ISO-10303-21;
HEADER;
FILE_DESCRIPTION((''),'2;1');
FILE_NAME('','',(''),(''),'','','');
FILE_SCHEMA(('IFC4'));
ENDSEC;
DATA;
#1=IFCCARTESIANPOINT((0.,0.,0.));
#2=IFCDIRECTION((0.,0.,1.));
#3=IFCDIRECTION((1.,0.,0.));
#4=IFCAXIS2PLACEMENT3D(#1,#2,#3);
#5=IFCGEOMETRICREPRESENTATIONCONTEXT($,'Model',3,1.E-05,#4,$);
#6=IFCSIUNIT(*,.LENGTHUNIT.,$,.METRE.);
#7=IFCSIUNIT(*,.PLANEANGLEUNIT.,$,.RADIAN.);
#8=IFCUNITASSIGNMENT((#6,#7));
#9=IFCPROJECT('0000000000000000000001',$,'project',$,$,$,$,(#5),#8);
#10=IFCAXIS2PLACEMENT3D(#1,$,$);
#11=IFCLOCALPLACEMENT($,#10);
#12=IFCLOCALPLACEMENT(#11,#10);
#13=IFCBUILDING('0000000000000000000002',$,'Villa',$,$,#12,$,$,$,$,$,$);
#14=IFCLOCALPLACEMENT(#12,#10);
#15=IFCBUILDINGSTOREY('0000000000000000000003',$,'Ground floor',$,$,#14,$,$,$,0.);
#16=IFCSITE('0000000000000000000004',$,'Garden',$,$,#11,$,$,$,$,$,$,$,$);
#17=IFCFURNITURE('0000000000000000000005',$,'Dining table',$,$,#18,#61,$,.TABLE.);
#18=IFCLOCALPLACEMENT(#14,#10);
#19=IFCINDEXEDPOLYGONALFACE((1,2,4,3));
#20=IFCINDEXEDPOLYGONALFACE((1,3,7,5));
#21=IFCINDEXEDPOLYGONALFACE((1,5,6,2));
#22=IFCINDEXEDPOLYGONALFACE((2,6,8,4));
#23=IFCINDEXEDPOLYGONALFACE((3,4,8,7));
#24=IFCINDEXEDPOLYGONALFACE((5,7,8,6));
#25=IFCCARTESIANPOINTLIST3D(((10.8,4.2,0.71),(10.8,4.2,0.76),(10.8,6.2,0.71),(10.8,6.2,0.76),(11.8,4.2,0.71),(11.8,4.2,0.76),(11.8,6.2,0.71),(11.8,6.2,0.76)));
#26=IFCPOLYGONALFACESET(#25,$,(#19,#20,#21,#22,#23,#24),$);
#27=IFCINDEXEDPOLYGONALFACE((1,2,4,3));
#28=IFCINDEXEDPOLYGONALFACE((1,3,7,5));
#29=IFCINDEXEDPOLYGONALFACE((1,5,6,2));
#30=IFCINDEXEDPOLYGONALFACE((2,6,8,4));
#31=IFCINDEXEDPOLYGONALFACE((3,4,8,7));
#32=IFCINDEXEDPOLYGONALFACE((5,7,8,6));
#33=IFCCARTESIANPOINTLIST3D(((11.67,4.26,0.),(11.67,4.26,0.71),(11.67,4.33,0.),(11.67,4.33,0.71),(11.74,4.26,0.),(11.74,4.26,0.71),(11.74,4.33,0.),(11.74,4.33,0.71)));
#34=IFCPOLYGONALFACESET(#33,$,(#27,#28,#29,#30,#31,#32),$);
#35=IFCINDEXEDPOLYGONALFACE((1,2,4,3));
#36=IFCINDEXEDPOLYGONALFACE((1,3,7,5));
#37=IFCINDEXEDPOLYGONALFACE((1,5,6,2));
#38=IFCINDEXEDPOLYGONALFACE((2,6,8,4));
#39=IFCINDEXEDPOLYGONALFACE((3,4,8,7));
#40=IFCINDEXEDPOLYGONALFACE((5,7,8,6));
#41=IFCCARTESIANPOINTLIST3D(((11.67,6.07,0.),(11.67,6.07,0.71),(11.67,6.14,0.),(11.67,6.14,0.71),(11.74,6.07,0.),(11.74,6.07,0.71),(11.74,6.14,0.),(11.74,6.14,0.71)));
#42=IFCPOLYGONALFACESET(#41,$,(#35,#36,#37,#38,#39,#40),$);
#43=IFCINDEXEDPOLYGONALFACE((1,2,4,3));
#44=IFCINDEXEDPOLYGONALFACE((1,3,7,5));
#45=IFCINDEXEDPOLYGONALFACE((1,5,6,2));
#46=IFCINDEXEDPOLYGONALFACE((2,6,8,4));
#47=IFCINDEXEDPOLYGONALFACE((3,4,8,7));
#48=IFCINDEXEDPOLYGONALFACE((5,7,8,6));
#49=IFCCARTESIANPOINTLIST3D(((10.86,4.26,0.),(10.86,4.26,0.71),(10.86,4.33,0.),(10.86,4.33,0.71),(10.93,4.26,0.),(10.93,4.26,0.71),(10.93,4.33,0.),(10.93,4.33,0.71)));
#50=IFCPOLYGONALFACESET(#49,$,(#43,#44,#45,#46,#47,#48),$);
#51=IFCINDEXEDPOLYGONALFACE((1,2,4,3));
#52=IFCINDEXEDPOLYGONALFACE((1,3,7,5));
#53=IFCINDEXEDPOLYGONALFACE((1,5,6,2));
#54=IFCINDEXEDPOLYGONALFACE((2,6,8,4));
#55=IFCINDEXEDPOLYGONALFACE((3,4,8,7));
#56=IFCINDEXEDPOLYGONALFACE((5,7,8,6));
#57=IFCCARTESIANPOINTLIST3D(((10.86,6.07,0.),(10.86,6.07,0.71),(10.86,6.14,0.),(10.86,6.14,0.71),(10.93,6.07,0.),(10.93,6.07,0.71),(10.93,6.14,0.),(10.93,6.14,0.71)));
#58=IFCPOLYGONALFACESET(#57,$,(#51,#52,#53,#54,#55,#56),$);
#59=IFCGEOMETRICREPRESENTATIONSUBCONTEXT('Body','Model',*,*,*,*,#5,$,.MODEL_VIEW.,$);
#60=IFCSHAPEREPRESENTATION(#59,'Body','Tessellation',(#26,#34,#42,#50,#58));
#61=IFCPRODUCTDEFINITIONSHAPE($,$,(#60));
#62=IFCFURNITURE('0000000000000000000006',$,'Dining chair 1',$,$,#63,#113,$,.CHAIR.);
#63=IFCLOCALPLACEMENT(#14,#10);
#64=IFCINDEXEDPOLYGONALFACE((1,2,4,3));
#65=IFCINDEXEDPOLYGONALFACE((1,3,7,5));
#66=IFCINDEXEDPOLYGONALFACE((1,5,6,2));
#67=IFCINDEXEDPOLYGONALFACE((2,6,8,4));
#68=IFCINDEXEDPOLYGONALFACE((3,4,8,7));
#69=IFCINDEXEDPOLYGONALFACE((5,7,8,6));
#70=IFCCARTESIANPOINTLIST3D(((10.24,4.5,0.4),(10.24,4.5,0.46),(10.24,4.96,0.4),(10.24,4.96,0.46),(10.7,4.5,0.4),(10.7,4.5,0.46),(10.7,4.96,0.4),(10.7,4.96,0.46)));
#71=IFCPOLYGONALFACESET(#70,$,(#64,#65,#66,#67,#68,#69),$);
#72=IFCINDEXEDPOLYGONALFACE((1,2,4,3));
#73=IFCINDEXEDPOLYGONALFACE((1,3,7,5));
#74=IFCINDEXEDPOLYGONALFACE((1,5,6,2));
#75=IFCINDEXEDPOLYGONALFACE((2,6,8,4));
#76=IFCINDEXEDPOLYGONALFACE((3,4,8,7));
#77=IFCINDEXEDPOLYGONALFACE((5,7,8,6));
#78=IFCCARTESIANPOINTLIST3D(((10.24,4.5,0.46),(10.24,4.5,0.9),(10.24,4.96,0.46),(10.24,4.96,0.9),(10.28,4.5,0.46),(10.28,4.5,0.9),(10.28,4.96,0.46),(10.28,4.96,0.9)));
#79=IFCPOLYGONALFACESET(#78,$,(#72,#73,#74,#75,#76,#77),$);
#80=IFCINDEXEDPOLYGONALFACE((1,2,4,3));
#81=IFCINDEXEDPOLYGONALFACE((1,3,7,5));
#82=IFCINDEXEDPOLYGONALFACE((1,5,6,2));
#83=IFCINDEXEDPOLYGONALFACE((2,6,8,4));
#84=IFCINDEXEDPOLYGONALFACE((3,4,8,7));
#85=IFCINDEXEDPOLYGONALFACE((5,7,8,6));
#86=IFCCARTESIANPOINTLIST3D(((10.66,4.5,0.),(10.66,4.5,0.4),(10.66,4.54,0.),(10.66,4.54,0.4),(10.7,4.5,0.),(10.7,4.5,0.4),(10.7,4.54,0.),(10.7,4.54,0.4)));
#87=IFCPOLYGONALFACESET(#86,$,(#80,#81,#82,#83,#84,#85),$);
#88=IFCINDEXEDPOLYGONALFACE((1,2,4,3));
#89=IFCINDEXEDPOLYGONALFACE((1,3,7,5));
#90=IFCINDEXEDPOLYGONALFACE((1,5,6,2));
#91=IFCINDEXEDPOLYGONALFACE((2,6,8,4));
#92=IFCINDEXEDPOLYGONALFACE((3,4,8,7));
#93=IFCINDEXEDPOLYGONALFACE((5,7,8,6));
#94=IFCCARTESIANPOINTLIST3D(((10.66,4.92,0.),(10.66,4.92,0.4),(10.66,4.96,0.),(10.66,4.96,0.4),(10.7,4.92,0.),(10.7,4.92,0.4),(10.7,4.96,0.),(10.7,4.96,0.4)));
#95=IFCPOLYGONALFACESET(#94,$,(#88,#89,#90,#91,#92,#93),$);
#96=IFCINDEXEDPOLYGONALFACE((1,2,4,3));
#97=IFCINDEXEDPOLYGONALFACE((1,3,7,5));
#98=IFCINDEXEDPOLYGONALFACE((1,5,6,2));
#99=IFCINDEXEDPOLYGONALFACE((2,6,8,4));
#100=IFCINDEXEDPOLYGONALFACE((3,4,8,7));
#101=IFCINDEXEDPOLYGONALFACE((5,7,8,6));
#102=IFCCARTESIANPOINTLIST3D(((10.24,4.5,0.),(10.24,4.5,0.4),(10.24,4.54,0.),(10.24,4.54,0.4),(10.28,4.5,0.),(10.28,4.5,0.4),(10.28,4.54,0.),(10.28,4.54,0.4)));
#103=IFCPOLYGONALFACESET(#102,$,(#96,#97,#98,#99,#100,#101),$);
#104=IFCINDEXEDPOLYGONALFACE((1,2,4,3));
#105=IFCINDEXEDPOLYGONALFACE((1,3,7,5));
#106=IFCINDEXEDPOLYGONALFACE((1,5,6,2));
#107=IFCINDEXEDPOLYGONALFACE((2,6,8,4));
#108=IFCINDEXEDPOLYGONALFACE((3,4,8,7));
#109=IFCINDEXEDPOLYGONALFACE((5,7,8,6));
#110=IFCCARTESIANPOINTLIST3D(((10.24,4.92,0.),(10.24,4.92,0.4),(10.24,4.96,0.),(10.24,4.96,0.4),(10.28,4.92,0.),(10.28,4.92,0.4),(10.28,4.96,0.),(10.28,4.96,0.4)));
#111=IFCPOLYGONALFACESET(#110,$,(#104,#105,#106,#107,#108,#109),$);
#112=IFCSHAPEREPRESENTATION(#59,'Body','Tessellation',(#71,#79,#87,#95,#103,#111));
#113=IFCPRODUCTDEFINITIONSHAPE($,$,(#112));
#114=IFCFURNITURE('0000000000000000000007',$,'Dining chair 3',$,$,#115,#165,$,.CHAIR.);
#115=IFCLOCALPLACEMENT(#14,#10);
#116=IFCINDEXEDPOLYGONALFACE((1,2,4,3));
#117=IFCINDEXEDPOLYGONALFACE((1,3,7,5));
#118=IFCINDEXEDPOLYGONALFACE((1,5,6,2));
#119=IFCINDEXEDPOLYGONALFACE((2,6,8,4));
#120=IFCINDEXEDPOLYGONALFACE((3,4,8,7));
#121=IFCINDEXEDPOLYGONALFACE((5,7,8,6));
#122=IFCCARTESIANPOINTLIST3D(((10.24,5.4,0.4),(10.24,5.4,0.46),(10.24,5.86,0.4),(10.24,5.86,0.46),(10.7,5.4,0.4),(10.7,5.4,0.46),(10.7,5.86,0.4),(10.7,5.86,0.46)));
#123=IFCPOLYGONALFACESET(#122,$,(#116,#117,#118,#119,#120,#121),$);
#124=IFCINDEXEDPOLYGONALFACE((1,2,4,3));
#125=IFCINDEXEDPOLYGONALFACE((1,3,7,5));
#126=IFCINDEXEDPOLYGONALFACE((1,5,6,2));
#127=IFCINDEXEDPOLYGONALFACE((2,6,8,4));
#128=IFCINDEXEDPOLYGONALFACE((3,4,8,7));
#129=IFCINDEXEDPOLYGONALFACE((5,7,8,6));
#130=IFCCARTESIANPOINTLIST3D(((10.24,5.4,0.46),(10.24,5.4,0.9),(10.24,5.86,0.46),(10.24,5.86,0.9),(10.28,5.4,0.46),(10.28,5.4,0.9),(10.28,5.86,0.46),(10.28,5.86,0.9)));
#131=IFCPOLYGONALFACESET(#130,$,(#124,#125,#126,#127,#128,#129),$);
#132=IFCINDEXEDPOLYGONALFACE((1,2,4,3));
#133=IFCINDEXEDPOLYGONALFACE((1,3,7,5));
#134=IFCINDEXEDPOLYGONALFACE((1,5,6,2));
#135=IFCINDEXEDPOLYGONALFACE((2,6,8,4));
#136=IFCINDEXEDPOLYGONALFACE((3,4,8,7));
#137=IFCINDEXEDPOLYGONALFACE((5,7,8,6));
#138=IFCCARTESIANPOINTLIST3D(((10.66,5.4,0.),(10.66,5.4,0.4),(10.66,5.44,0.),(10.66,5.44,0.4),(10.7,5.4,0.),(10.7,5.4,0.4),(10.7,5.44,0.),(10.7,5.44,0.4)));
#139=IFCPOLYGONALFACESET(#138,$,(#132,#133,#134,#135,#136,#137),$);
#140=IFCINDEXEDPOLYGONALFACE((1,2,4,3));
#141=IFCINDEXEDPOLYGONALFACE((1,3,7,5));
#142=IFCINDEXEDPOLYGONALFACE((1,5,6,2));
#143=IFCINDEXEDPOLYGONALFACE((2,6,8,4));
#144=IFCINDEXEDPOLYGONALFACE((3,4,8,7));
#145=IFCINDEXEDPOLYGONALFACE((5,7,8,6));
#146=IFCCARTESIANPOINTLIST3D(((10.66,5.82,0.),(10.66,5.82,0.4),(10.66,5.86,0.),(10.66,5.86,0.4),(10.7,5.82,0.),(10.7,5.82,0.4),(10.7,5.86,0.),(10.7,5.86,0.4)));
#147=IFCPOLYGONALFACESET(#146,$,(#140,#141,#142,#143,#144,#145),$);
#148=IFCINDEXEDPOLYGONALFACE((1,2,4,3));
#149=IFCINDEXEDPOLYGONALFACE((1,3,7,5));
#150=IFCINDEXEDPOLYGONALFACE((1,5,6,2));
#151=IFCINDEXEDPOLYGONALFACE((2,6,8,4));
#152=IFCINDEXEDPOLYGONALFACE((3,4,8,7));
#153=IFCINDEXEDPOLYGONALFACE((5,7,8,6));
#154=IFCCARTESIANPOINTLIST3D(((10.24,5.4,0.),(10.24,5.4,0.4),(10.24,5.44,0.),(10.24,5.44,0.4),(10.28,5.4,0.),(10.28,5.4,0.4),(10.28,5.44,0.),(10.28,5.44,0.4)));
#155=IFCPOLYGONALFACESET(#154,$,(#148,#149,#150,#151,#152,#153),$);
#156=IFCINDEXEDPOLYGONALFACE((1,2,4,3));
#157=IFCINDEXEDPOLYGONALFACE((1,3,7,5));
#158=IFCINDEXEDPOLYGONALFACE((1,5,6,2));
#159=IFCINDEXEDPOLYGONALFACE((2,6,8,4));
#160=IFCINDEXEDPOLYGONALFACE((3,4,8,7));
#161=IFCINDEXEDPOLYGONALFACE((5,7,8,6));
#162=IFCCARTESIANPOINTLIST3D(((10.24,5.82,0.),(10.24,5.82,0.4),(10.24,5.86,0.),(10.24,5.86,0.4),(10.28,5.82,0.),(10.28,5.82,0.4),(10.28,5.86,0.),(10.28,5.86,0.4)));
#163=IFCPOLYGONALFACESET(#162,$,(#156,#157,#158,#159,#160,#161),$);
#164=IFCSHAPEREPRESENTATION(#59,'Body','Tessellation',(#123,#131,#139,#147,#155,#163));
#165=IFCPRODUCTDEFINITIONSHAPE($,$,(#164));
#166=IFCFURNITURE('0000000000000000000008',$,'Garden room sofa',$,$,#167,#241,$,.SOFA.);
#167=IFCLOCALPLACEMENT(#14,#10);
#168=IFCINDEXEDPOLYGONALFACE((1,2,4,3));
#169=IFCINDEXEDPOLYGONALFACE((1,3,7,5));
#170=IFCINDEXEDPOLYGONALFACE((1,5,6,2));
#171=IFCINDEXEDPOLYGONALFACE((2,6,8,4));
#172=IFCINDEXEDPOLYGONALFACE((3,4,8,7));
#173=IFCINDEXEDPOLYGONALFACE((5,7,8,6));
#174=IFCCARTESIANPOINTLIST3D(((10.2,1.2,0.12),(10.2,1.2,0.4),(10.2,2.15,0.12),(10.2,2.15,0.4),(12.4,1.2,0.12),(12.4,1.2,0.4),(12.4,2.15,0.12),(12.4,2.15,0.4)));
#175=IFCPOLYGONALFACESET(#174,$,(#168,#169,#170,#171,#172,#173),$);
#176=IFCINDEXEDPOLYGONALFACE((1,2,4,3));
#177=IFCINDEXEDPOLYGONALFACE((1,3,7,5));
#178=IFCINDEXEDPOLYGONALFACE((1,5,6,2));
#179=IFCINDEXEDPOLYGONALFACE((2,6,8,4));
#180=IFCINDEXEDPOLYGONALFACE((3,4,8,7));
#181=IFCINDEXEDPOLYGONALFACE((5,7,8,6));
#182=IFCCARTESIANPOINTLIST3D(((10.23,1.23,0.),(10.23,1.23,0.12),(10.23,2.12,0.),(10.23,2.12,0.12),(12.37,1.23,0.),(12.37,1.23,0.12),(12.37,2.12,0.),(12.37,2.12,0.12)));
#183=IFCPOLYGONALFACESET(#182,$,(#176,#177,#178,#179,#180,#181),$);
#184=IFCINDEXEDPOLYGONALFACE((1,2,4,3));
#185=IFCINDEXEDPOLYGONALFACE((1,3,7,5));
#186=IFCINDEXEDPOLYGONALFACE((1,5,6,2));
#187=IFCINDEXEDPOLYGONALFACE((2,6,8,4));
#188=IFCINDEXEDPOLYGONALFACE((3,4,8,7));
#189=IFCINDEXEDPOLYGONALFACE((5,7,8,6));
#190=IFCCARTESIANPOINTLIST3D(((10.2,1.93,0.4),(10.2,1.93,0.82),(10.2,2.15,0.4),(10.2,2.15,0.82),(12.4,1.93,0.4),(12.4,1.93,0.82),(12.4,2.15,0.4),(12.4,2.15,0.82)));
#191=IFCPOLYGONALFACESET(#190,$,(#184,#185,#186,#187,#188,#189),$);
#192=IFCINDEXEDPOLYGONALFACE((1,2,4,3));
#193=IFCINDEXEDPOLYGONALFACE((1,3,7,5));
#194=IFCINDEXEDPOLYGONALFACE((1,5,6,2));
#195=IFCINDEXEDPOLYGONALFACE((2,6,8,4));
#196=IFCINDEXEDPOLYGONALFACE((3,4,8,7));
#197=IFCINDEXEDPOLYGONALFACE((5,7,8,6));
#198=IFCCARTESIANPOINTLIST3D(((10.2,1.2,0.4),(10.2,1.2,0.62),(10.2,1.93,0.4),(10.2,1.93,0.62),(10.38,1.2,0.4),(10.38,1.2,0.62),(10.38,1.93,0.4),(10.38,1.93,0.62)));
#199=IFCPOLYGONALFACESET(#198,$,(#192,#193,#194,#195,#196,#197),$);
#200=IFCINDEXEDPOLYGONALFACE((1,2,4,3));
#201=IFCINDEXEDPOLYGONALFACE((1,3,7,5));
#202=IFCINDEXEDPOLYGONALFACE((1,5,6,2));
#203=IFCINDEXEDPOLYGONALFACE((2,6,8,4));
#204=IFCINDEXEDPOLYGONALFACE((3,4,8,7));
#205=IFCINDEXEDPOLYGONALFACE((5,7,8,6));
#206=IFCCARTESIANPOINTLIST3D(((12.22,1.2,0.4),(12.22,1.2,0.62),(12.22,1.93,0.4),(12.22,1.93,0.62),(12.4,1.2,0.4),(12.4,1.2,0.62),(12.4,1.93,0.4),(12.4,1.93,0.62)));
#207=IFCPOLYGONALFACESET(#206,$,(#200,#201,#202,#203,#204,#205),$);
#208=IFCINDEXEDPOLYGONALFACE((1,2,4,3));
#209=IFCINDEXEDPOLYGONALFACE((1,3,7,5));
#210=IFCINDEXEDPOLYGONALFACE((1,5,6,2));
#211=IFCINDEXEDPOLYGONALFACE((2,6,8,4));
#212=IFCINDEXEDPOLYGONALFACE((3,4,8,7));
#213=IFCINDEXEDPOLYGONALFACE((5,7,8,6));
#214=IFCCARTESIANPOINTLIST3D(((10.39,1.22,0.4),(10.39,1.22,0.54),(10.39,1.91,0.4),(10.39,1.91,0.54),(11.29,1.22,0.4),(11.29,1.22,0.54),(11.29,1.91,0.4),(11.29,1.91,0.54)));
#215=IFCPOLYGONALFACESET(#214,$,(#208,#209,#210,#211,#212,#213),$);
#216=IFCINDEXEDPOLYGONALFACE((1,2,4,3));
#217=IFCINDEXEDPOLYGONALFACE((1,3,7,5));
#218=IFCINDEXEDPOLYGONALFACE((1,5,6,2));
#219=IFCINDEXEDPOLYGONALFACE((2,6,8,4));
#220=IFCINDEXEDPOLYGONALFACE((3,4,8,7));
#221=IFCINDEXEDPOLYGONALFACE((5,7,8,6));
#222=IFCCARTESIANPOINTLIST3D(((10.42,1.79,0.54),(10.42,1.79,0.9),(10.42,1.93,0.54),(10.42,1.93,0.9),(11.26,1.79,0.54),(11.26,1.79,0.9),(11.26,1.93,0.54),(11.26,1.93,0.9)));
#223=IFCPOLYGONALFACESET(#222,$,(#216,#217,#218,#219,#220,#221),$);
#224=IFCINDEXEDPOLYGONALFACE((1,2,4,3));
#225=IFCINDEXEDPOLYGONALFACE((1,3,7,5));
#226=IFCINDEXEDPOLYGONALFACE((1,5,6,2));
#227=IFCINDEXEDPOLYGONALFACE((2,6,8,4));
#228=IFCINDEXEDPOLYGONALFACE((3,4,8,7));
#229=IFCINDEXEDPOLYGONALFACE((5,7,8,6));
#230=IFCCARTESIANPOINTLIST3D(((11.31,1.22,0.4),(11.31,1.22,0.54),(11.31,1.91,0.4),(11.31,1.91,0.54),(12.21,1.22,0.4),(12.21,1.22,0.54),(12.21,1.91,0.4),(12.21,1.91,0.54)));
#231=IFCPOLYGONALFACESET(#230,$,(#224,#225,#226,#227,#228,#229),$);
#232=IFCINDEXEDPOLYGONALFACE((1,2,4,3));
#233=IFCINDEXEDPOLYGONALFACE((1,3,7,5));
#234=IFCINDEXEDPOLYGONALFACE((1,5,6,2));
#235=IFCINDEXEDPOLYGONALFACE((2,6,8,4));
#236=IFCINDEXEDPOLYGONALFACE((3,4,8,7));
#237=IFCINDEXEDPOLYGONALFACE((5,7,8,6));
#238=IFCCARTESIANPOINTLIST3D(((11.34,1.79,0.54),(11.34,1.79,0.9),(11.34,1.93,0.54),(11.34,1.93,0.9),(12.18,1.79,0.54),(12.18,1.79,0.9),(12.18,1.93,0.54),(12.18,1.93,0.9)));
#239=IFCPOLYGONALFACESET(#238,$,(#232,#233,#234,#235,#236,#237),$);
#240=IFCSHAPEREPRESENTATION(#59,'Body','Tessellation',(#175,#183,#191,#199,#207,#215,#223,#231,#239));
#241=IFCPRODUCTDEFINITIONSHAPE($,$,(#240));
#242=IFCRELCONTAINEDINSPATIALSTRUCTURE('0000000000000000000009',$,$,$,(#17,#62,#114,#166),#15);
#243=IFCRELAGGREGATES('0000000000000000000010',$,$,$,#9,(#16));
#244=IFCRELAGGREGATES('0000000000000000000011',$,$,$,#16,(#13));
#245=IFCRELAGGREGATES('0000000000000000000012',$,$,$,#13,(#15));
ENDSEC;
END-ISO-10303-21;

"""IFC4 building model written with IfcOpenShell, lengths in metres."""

from ifc_helpers import new_model, si_unit, frame, frame_2d, origin, origin_with_axes, place, context, subcontext, project, spatial, rectangle, extrude, element, save


model = new_model("IFC4")

# Units and contexts
model_context = context("Model", 3, precision=1e-05, world=origin_with_axes())
body_context = subcontext(model_context, "Body", "Model", "MODEL_VIEW")
ifc_project = project(units=[si_unit("LENGTHUNIT", "METRE"), si_unit("PLANEANGLEUNIT", "RADIAN")], contexts=[model_context])

# Site, building, storey
site_placement = place(None, origin())
site = spatial("IfcSite", under=ifc_project, at=site_placement, Name="Garden")
building_placement = place(site_placement, origin())
building = spatial("IfcBuilding", under=site, at=building_placement, Name="Villa")
storey_placement = place(building_placement, origin())
storey = spatial("IfcBuildingStorey", under=building, at=storey_placement, Name="Ground floor", Elevation=0.0)

# Furniture
furniture_1_placement = place(storey_placement, frame((11.8, 4.2, 0.0), x_axis=(0.0, 1.0, 0.0)))
element("IfcFurniture", 1, at=furniture_1_placement, inside=storey, Name="Dining table", PredefinedType="TABLE", context=body_context, shape_type="SweptSolid", body=[
    extrude(rectangle(XDim=2.0, YDim=1.0, at=frame_2d((1.0, 0.5))), frame((0.0, 0.0, 0.71)), (0.0, 0.0, 1.0), 0.05),
    extrude(rectangle(XDim=0.07, YDim=0.07, at=frame_2d((0.035, 0.035))), frame((0.06, 0.06, 0.0)), (0.0, 0.0, 1.0), 0.71),
    extrude(rectangle(XDim=0.07, YDim=0.07, at=frame_2d((0.035, 0.035))), frame((1.87, 0.06, 0.0)), (0.0, 0.0, 1.0), 0.71),
    extrude(rectangle(XDim=0.07, YDim=0.07, at=frame_2d((0.035, 0.035))), frame((0.06, 0.87, 0.0)), (0.0, 0.0, 1.0), 0.71),
    extrude(rectangle(XDim=0.07, YDim=0.07, at=frame_2d((0.035, 0.035))), frame((1.87, 0.87, 0.0)), (0.0, 0.0, 1.0), 0.71),
])
for number, where, x_axis, name in (
    (2, (10.7, 4.5, 0.0), (0.0, 1.0, 0.0), "Dining chair 1"),
    (3, (10.7, 5.4, 0.0), (0.0, 1.0, 0.0), "Dining chair 3"),
):
    element("IfcFurniture", number, at=place(storey_placement, frame(where, x_axis=x_axis)), inside=storey, Name=name, PredefinedType="CHAIR", context=body_context, shape_type="SweptSolid", body=[
        extrude(rectangle(XDim=0.46, YDim=0.46, at=frame_2d((0.23, 0.23))), frame((0.0, 0.0, 0.4)), (0.0, 0.0, 1.0), 0.06),
        extrude(rectangle(XDim=0.46, YDim=0.04, at=frame_2d((0.23, 0.02))), frame((0.0, 0.42, 0.46)), (0.0, 0.0, 1.0), 0.44),
        extrude(rectangle(XDim=0.04, YDim=0.04, at=frame_2d((0.02, 0.02))), origin(), (0.0, 0.0, 1.0), 0.4),
        extrude(rectangle(XDim=0.04, YDim=0.04, at=frame_2d((0.02, 0.02))), frame((0.42, 0.0, 0.0)), (0.0, 0.0, 1.0), 0.4),
        extrude(rectangle(XDim=0.04, YDim=0.04, at=frame_2d((0.02, 0.02))), frame((0.0, 0.42, 0.0)), (0.0, 0.0, 1.0), 0.4),
        extrude(rectangle(XDim=0.04, YDim=0.04, at=frame_2d((0.02, 0.02))), frame((0.42, 0.42, 0.0)), (0.0, 0.0, 1.0), 0.4),
    ])
furniture_2_placement = place(storey_placement, frame((10.2, 1.2, 0.0)))
element("IfcFurniture", 4, at=furniture_2_placement, inside=storey, Name="Garden room sofa", PredefinedType="SOFA", context=body_context, shape_type="SweptSolid", body=[
    extrude(rectangle(XDim=2.2, YDim=0.95, at=frame_2d((1.1, 0.475))), frame((0.0, 0.0, 0.12)), (0.0, 0.0, 1.0), 0.28),
    extrude(rectangle(XDim=2.14, YDim=0.89, at=frame_2d((1.07, 0.445))), frame((0.03, 0.03, 0.0)), (0.0, 0.0, 1.0), 0.12),
    extrude(rectangle(XDim=2.2, YDim=0.22, at=frame_2d((1.1, 0.11))), frame((0.0, 0.73, 0.4)), (0.0, 0.0, 1.0), 0.42),
    extrude(rectangle(XDim=0.18, YDim=0.73, at=frame_2d((0.09, 0.365))), frame((0.0, 0.0, 0.4)), (0.0, 0.0, 1.0), 0.22),
    extrude(rectangle(XDim=0.18, YDim=0.73, at=frame_2d((0.09, 0.365))), frame((2.02, 0.0, 0.4)), (0.0, 0.0, 1.0), 0.22),
    extrude(rectangle(XDim=0.9, YDim=0.69, at=frame_2d((0.45, 0.345))), frame((0.19, 0.02, 0.4)), (0.0, 0.0, 1.0), 0.14),
    extrude(rectangle(XDim=0.84, YDim=0.14, at=frame_2d((0.42, 0.07))), frame((0.22, 0.59, 0.54)), (0.0, 0.0, 1.0), 0.36),
    extrude(rectangle(XDim=0.9, YDim=0.69, at=frame_2d((0.45, 0.345))), frame((1.11, 0.02, 0.4)), (0.0, 0.0, 1.0), 0.14),
    extrude(rectangle(XDim=0.84, YDim=0.14, at=frame_2d((0.42, 0.07))), frame((1.14, 0.59, 0.54)), (0.0, 0.0, 1.0), 0.36),
])

save(model, "model.ifc")
